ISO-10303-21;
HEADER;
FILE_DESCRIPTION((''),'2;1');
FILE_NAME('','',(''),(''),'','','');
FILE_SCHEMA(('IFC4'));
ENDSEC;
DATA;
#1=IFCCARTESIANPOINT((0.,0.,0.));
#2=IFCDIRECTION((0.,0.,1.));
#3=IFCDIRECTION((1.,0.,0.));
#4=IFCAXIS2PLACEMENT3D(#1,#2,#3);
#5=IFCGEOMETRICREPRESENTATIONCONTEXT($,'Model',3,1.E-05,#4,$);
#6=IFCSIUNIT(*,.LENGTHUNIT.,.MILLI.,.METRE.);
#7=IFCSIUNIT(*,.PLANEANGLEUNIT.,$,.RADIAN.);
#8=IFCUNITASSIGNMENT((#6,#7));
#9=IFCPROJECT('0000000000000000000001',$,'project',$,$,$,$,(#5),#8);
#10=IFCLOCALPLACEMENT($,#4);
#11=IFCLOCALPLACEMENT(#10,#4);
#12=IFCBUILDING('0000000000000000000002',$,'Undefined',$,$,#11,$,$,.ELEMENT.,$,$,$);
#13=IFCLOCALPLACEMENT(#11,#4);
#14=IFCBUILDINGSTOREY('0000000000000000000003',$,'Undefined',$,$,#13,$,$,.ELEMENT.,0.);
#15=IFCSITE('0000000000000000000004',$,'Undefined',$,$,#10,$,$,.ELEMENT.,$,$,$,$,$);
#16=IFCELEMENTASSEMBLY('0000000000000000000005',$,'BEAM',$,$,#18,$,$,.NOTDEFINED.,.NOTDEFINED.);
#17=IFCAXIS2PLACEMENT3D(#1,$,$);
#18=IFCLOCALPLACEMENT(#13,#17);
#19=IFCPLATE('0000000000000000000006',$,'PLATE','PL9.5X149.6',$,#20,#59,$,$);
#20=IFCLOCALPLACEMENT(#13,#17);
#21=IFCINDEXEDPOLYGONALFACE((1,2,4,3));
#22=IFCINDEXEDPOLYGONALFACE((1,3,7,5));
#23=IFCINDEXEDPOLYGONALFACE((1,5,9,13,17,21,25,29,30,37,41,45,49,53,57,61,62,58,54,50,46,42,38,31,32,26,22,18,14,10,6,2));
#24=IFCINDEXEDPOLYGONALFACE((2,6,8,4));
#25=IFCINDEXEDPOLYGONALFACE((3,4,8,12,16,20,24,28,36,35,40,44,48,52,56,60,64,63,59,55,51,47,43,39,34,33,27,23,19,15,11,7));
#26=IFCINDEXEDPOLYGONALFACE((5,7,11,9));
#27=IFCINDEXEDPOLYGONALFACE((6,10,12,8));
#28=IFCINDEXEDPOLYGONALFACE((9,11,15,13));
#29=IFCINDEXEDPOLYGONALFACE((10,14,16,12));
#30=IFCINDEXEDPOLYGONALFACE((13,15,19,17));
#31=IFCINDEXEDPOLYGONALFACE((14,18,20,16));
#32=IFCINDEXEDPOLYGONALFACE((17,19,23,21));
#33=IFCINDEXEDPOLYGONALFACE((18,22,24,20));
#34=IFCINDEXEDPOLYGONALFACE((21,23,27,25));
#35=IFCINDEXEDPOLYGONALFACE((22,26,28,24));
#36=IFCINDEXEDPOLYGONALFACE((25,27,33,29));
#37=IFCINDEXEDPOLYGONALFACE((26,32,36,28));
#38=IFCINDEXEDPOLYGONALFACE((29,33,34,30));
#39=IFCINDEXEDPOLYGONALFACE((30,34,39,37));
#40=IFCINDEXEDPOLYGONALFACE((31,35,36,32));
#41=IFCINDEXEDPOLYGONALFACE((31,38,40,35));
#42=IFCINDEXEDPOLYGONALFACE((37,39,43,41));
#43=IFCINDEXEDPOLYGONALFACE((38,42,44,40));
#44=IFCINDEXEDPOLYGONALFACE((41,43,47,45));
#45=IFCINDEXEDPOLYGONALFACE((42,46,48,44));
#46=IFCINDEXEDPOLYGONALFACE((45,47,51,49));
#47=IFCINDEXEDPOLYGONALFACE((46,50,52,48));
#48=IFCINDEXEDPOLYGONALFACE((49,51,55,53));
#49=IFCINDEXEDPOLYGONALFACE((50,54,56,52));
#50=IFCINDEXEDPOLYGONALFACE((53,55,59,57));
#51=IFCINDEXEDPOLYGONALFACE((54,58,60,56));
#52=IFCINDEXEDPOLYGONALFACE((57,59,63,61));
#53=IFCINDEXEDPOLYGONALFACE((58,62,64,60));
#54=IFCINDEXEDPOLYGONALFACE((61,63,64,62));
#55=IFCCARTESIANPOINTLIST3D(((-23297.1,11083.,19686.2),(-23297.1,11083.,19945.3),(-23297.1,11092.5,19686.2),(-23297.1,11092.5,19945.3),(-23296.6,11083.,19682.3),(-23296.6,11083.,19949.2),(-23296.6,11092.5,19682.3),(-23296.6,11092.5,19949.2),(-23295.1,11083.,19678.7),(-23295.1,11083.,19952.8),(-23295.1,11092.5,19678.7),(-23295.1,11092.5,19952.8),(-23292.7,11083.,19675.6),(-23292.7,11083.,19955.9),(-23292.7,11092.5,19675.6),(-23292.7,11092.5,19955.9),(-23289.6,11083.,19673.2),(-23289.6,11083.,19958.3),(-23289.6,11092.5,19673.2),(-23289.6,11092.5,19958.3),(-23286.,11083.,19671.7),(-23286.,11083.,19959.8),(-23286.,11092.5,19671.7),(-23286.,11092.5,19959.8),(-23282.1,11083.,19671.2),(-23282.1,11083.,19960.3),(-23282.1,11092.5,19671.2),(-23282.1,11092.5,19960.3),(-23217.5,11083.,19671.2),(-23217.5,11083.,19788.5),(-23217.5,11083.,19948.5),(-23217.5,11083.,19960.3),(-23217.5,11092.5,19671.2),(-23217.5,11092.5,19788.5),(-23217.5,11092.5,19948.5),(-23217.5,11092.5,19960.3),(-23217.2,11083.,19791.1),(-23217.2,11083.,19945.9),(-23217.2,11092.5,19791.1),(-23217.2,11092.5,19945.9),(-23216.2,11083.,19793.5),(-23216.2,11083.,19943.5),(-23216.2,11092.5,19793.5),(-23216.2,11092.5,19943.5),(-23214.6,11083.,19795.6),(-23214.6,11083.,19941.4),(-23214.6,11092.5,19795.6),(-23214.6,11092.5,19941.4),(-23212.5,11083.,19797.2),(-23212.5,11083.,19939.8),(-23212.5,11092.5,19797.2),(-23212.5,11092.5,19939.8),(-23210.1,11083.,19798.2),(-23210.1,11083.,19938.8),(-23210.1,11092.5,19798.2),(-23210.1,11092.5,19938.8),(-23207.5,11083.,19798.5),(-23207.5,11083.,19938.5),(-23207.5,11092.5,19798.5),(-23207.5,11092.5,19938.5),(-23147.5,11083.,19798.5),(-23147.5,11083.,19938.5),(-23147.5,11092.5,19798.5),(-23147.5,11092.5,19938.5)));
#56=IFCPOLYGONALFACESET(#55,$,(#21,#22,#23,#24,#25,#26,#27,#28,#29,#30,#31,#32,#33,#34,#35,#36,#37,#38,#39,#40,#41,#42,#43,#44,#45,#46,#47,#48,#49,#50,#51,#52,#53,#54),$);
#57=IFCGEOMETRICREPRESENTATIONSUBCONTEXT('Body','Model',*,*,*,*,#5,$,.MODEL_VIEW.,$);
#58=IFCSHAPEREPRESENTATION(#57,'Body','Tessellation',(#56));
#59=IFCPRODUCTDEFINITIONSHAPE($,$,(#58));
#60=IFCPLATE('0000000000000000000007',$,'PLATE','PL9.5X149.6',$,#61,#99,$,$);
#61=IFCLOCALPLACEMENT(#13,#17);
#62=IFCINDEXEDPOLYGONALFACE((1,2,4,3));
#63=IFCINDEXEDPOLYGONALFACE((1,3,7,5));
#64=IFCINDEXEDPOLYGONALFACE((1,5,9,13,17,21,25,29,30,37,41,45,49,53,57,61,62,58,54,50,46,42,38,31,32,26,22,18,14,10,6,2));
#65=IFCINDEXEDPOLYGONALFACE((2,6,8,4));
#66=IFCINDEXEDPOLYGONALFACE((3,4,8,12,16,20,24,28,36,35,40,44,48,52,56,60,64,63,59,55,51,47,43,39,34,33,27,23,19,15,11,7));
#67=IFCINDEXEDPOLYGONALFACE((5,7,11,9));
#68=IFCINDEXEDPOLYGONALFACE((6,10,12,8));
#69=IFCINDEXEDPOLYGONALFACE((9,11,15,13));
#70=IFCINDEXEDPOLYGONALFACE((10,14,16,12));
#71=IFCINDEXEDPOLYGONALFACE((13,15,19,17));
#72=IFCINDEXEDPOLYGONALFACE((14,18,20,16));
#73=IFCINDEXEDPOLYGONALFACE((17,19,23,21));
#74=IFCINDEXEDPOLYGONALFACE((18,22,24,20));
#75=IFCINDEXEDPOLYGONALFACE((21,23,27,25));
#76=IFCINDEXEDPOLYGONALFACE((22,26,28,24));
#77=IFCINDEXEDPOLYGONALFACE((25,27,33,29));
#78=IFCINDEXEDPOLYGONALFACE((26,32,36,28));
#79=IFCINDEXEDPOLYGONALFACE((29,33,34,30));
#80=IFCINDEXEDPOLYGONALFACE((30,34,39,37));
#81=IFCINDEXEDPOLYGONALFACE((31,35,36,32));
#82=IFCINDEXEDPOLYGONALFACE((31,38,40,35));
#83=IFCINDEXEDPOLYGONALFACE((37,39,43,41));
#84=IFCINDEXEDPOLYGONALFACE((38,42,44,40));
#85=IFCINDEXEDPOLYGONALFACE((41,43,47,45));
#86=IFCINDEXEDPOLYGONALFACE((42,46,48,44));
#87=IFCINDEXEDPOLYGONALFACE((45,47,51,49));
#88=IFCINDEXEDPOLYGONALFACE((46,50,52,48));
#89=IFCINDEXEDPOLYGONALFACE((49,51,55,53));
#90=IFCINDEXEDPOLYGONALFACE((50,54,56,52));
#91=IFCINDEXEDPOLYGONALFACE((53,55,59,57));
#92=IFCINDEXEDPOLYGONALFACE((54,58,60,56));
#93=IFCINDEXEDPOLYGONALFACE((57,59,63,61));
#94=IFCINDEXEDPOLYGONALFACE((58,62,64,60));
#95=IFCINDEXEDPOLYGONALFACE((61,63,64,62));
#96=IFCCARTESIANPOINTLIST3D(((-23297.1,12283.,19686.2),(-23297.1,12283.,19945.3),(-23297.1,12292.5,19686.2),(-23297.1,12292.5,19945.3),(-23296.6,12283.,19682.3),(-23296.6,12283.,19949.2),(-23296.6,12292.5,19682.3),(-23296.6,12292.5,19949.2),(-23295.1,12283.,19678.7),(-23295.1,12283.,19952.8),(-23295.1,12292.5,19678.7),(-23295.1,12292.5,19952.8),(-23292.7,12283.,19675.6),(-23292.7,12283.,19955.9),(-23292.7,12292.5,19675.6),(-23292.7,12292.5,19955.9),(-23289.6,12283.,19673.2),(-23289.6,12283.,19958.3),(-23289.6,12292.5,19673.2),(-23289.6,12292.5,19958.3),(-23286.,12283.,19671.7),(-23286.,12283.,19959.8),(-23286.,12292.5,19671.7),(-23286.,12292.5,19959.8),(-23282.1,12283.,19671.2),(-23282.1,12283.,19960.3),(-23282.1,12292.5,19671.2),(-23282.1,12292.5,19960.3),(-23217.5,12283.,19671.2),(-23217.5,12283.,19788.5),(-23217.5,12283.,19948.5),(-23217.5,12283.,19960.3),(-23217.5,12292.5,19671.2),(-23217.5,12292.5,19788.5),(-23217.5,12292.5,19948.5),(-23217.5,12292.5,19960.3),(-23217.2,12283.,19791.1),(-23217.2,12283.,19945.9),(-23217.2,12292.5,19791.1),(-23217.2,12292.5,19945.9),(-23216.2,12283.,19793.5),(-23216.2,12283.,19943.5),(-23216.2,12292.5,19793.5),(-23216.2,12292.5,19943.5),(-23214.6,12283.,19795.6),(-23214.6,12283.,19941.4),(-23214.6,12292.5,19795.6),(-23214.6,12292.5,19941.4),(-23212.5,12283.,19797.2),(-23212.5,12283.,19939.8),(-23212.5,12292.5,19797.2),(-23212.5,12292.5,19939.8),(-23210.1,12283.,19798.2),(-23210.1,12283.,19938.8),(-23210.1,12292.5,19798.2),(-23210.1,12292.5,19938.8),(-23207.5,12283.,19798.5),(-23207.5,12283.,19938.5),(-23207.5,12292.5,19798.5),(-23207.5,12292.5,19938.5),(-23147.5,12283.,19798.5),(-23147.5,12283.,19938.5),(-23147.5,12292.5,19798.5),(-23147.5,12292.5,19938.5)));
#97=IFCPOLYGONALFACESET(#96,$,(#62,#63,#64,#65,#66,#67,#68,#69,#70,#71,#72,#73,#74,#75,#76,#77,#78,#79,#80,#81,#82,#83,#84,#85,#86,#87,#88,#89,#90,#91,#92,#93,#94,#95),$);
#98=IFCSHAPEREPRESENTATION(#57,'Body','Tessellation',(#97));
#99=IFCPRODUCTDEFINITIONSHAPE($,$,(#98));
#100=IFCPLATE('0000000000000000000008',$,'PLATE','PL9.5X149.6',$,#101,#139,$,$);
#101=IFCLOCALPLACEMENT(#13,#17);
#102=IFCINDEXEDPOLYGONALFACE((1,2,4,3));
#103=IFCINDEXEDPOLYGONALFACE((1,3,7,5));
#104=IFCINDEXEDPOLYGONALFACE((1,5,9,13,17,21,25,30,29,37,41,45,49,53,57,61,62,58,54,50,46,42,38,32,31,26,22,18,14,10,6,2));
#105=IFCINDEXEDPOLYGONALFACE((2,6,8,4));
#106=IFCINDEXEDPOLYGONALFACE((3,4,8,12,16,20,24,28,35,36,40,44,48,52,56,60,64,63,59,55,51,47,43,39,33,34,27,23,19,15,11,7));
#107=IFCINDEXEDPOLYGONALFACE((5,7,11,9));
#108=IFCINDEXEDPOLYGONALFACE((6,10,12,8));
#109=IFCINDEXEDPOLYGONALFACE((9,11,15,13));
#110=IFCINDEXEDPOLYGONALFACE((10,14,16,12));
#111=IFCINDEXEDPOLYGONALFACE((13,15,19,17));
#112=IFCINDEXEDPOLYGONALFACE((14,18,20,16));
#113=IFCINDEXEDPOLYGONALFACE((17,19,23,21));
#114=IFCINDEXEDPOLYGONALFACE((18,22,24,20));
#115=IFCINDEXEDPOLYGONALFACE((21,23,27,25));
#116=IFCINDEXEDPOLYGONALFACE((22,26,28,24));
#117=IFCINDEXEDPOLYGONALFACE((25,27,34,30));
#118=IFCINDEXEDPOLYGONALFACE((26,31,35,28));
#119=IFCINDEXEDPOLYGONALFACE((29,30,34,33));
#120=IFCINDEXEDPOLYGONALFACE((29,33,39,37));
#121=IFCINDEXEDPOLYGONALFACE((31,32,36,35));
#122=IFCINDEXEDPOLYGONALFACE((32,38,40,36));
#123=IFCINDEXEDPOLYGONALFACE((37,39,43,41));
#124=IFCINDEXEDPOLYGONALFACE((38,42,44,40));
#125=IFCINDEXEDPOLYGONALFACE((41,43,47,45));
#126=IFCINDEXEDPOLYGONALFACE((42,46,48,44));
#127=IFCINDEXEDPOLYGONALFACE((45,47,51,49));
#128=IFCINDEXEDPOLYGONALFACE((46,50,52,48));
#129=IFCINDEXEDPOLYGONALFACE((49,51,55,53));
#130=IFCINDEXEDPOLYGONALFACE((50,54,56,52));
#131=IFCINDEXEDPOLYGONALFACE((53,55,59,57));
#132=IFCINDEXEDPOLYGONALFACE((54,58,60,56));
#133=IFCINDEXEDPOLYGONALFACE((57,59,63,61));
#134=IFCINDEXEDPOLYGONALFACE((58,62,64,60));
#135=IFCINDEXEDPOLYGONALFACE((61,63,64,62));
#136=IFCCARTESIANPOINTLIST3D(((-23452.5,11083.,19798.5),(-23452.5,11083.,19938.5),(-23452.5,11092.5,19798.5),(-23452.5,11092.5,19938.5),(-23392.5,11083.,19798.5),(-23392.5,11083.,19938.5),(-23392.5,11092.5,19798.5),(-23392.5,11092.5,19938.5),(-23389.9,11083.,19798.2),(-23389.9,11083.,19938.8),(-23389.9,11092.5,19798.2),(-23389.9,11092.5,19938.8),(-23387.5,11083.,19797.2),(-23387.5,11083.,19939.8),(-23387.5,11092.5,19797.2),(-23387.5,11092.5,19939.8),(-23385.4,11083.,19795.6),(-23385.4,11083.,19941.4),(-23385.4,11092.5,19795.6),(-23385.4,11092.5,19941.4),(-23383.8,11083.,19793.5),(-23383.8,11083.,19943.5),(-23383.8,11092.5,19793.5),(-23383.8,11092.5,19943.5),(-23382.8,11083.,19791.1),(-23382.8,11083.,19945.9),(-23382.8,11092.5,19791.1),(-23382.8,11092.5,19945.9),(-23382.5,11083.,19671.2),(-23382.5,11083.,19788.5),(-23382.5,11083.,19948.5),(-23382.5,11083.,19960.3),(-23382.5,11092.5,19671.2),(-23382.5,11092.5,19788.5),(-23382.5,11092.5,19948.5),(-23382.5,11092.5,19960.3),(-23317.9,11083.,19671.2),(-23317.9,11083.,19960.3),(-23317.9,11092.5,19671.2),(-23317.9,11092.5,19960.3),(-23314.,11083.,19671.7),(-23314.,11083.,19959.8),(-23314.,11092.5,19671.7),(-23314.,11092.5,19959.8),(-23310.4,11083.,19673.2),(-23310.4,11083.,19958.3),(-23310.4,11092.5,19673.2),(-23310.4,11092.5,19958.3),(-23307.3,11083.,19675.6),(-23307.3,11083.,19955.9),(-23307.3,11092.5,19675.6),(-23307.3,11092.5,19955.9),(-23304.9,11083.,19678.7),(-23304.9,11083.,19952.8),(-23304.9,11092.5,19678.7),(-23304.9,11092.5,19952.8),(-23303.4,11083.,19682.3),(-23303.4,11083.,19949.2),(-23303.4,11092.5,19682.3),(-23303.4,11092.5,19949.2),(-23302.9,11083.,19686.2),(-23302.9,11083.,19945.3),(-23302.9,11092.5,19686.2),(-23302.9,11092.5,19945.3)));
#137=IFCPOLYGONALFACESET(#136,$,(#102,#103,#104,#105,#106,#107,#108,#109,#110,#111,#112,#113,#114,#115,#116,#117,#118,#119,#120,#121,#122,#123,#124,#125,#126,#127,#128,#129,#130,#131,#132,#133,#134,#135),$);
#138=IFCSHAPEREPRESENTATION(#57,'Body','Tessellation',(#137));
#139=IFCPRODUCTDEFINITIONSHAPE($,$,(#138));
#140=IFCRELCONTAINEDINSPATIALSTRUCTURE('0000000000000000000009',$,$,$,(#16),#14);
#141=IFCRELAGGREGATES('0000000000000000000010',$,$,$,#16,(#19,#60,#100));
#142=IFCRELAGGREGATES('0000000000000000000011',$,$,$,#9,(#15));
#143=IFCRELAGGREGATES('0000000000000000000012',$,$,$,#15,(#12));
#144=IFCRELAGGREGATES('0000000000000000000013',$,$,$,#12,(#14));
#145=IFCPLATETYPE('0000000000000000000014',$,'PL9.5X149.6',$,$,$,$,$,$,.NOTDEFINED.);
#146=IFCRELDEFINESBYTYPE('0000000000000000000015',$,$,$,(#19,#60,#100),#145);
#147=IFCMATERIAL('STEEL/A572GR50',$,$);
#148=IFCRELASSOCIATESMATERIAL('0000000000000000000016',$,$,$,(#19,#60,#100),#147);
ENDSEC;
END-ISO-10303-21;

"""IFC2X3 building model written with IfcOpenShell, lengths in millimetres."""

from ifc_helpers import new_model, si_unit, frame, frame_2d, origin_with_axes, place, context, subcontext, project, spatial, polyline, circle_curve, parameter, trimmed, segment, composite_curve, outline, extrude, material, type_object, element, aggregate, save


model = new_model("IFC2X3")

# Units and contexts
model_context = context("Model", 3, precision=1e-05, world=origin_with_axes())
body_context = subcontext(model_context, "Body", "Model", "MODEL_VIEW")
ifc_project = project(units=[si_unit("LENGTHUNIT", "METRE", prefix="MILLI"), si_unit("PLANEANGLEUNIT", "RADIAN")], contexts=[model_context])

# Site, building, storey
site_placement = place(None, origin_with_axes())
site = spatial("IfcSite", under=ifc_project, at=site_placement, Name="Undefined", CompositionType="ELEMENT")
building_placement = place(site_placement, origin_with_axes())
building = spatial("IfcBuilding", under=site, at=building_placement, Name="Undefined", CompositionType="ELEMENT")
storey_placement = place(building_placement, origin_with_axes())
storey = spatial("IfcBuildingStorey", under=building, at=storey_placement, Name="Undefined", CompositionType="ELEMENT", Elevation=0.0)

# Shared definitions
ifc_material_1 = material(Name="STEEL/A572GR50")

# Element assembly, plates
assembly_1_placement = place(storey_placement, origin_with_axes())
assembly_1 = element("IfcElementAssembly", 1, at=assembly_1_placement, inside=storey, Name="BEAM", AssemblyPlace="NOTDEFINED", PredefinedType="NOTDEFINED")
plate_type_1 = type_object("IfcPlateType", Name="PL9.5X149.6", PredefinedType="NOTDEFINED")
plate_1_placement = place(assembly_1_placement, frame((-23297.1, 11087.7, 19960.3), z_axis=(0.0, -1.0, 0.0), x_axis=(0.0, 0.0, -1.0)))
plate_1 = element("IfcPlate", 2, at=plate_1_placement, type_object=plate_type_1, material=ifc_material_1, Name="PLATE", Description="PL9.5X149.6", context=body_context, shape_type="SweptSolid", body=[
    extrude(outline(composite_curve([segment(trimmed(circle_curve(frame_2d((15.0, 15.0), x_axis=(-1.0, 0.0)), 15.0), [parameter(0.0)], [parameter(1.570796)], True, "PARAMETER"), True, "CONTINUOUS"), segment(polyline([(15.0, 0.0), (274.1, 0.0)]), True, "CONTINUOUS"), segment(trimmed(circle_curve(frame_2d((274.1, 15.0), x_axis=(0.0, -1.0)), 15.0), [parameter(0.0)], [parameter(1.570796)], True, "PARAMETER"), True, "CONTINUOUS"), segment(polyline([(289.1, 15.0), (289.1, 79.6), (171.8, 79.6)]), True, "CONTINUOUS"), segment(trimmed(circle_curve(frame_2d((171.8, 89.6), x_axis=(0.0, -1.0)), 10.0), [parameter(0.0)], [parameter(4.712389)], False, "PARAMETER"), True, "CONTINUOUS"), segment(polyline([(161.8, 89.6), (161.8, 149.6), (21.8, 149.6), (21.8, 89.6)]), True, "CONTINUOUS"), segment(trimmed(circle_curve(frame_2d((11.8, 89.6), x_axis=(1.0, 0.0)), 10.0), [parameter(0.0)], [parameter(4.712389)], False, "PARAMETER"), True, "CONTINUOUS"), segment(polyline([(11.8, 79.6), (0.0, 79.6), (0.0, 15.0)]), True, "CONTINUOUS")], self_intersect=True)), frame((0.0, 0.0, -4.8), z_axis=(0.0, 0.0, 1.0), x_axis=(1.0, 0.0, 0.0)), (0.0, 0.0, 1.0), 9.5),
])
plate_2_placement = place(assembly_1_placement, frame((-23297.1, 12287.7, 19960.3), z_axis=(0.0, -1.0, 0.0), x_axis=(0.0, 0.0, -1.0)))
plate_2 = element("IfcPlate", 3, at=plate_2_placement, type_object=plate_type_1, material=ifc_material_1, Name="PLATE", Description="PL9.5X149.6", context=body_context, shape_type="SweptSolid", body=[
    extrude(outline(composite_curve([segment(trimmed(circle_curve(frame_2d((15.0, 15.0), x_axis=(-1.0, 0.0)), 15.0), [parameter(0.0)], [parameter(1.570796)], True, "PARAMETER"), True, "CONTINUOUS"), segment(polyline([(15.0, 0.0), (274.1, 0.0)]), True, "CONTINUOUS"), segment(trimmed(circle_curve(frame_2d((274.1, 15.0), x_axis=(0.0, -1.0)), 15.0), [parameter(0.0)], [parameter(1.570796)], True, "PARAMETER"), True, "CONTINUOUS"), segment(polyline([(289.1, 15.0), (289.1, 79.6), (171.8, 79.6)]), True, "CONTINUOUS"), segment(trimmed(circle_curve(frame_2d((171.8, 89.6), x_axis=(0.0, -1.0)), 10.0), [parameter(0.0)], [parameter(4.712389)], False, "PARAMETER"), True, "CONTINUOUS"), segment(polyline([(161.8, 89.6), (161.8, 149.6), (21.8, 149.6), (21.8, 89.6)]), True, "CONTINUOUS"), segment(trimmed(circle_curve(frame_2d((11.8, 89.6), x_axis=(1.0, 0.0)), 10.0), [parameter(0.0)], [parameter(4.712389)], False, "PARAMETER"), True, "CONTINUOUS"), segment(polyline([(11.8, 79.6), (0.0, 79.6), (0.0, 15.0)]), True, "CONTINUOUS")], self_intersect=True)), frame((0.0, 0.0, -4.8), z_axis=(0.0, 0.0, 1.0), x_axis=(1.0, 0.0, 0.0)), (0.0, 0.0, 1.0), 9.5),
])
plate_3_placement = place(assembly_1_placement, frame((-23302.9, 11087.7, 19960.3), z_axis=(0.0, 1.0, 0.0), x_axis=(0.0, 0.0, -1.0)))
plate_3 = element("IfcPlate", 4, at=plate_3_placement, type_object=plate_type_1, material=ifc_material_1, Name="PLATE", Description="PL9.5X149.6", context=body_context, shape_type="SweptSolid", body=[
    extrude(outline(composite_curve([segment(trimmed(circle_curve(frame_2d((15.0, 15.0), x_axis=(-1.0, 0.0)), 15.0), [parameter(0.0)], [parameter(1.570796)], True, "PARAMETER"), True, "CONTINUOUS"), segment(polyline([(15.0, 0.0), (274.1, 0.0)]), True, "CONTINUOUS"), segment(trimmed(circle_curve(frame_2d((274.1, 15.0), x_axis=(0.0, -1.0)), 15.0), [parameter(0.0)], [parameter(1.570796)], True, "PARAMETER"), True, "CONTINUOUS"), segment(polyline([(289.1, 15.0), (289.1, 79.6), (171.8, 79.6)]), True, "CONTINUOUS"), segment(trimmed(circle_curve(frame_2d((171.8, 89.6), x_axis=(0.0, -1.0)), 10.0), [parameter(0.0)], [parameter(4.712389)], False, "PARAMETER"), True, "CONTINUOUS"), segment(polyline([(161.8, 89.6), (161.8, 149.6), (21.8, 149.6), (21.8, 89.6)]), True, "CONTINUOUS"), segment(trimmed(circle_curve(frame_2d((11.8, 89.6), x_axis=(1.0, 0.0)), 10.0), [parameter(0.0)], [parameter(4.712389)], False, "PARAMETER"), True, "CONTINUOUS"), segment(polyline([(11.8, 79.6), (0.0, 79.6), (0.0, 15.0)]), True, "CONTINUOUS")], self_intersect=True)), frame((0.0, 0.0, -4.8), z_axis=(0.0, 0.0, 1.0), x_axis=(1.0, 0.0, 0.0)), (0.0, 0.0, 1.0), 9.5),
])

aggregate(assembly_1, [plate_1, plate_2, plate_3])

save(model, "model.ifc")
